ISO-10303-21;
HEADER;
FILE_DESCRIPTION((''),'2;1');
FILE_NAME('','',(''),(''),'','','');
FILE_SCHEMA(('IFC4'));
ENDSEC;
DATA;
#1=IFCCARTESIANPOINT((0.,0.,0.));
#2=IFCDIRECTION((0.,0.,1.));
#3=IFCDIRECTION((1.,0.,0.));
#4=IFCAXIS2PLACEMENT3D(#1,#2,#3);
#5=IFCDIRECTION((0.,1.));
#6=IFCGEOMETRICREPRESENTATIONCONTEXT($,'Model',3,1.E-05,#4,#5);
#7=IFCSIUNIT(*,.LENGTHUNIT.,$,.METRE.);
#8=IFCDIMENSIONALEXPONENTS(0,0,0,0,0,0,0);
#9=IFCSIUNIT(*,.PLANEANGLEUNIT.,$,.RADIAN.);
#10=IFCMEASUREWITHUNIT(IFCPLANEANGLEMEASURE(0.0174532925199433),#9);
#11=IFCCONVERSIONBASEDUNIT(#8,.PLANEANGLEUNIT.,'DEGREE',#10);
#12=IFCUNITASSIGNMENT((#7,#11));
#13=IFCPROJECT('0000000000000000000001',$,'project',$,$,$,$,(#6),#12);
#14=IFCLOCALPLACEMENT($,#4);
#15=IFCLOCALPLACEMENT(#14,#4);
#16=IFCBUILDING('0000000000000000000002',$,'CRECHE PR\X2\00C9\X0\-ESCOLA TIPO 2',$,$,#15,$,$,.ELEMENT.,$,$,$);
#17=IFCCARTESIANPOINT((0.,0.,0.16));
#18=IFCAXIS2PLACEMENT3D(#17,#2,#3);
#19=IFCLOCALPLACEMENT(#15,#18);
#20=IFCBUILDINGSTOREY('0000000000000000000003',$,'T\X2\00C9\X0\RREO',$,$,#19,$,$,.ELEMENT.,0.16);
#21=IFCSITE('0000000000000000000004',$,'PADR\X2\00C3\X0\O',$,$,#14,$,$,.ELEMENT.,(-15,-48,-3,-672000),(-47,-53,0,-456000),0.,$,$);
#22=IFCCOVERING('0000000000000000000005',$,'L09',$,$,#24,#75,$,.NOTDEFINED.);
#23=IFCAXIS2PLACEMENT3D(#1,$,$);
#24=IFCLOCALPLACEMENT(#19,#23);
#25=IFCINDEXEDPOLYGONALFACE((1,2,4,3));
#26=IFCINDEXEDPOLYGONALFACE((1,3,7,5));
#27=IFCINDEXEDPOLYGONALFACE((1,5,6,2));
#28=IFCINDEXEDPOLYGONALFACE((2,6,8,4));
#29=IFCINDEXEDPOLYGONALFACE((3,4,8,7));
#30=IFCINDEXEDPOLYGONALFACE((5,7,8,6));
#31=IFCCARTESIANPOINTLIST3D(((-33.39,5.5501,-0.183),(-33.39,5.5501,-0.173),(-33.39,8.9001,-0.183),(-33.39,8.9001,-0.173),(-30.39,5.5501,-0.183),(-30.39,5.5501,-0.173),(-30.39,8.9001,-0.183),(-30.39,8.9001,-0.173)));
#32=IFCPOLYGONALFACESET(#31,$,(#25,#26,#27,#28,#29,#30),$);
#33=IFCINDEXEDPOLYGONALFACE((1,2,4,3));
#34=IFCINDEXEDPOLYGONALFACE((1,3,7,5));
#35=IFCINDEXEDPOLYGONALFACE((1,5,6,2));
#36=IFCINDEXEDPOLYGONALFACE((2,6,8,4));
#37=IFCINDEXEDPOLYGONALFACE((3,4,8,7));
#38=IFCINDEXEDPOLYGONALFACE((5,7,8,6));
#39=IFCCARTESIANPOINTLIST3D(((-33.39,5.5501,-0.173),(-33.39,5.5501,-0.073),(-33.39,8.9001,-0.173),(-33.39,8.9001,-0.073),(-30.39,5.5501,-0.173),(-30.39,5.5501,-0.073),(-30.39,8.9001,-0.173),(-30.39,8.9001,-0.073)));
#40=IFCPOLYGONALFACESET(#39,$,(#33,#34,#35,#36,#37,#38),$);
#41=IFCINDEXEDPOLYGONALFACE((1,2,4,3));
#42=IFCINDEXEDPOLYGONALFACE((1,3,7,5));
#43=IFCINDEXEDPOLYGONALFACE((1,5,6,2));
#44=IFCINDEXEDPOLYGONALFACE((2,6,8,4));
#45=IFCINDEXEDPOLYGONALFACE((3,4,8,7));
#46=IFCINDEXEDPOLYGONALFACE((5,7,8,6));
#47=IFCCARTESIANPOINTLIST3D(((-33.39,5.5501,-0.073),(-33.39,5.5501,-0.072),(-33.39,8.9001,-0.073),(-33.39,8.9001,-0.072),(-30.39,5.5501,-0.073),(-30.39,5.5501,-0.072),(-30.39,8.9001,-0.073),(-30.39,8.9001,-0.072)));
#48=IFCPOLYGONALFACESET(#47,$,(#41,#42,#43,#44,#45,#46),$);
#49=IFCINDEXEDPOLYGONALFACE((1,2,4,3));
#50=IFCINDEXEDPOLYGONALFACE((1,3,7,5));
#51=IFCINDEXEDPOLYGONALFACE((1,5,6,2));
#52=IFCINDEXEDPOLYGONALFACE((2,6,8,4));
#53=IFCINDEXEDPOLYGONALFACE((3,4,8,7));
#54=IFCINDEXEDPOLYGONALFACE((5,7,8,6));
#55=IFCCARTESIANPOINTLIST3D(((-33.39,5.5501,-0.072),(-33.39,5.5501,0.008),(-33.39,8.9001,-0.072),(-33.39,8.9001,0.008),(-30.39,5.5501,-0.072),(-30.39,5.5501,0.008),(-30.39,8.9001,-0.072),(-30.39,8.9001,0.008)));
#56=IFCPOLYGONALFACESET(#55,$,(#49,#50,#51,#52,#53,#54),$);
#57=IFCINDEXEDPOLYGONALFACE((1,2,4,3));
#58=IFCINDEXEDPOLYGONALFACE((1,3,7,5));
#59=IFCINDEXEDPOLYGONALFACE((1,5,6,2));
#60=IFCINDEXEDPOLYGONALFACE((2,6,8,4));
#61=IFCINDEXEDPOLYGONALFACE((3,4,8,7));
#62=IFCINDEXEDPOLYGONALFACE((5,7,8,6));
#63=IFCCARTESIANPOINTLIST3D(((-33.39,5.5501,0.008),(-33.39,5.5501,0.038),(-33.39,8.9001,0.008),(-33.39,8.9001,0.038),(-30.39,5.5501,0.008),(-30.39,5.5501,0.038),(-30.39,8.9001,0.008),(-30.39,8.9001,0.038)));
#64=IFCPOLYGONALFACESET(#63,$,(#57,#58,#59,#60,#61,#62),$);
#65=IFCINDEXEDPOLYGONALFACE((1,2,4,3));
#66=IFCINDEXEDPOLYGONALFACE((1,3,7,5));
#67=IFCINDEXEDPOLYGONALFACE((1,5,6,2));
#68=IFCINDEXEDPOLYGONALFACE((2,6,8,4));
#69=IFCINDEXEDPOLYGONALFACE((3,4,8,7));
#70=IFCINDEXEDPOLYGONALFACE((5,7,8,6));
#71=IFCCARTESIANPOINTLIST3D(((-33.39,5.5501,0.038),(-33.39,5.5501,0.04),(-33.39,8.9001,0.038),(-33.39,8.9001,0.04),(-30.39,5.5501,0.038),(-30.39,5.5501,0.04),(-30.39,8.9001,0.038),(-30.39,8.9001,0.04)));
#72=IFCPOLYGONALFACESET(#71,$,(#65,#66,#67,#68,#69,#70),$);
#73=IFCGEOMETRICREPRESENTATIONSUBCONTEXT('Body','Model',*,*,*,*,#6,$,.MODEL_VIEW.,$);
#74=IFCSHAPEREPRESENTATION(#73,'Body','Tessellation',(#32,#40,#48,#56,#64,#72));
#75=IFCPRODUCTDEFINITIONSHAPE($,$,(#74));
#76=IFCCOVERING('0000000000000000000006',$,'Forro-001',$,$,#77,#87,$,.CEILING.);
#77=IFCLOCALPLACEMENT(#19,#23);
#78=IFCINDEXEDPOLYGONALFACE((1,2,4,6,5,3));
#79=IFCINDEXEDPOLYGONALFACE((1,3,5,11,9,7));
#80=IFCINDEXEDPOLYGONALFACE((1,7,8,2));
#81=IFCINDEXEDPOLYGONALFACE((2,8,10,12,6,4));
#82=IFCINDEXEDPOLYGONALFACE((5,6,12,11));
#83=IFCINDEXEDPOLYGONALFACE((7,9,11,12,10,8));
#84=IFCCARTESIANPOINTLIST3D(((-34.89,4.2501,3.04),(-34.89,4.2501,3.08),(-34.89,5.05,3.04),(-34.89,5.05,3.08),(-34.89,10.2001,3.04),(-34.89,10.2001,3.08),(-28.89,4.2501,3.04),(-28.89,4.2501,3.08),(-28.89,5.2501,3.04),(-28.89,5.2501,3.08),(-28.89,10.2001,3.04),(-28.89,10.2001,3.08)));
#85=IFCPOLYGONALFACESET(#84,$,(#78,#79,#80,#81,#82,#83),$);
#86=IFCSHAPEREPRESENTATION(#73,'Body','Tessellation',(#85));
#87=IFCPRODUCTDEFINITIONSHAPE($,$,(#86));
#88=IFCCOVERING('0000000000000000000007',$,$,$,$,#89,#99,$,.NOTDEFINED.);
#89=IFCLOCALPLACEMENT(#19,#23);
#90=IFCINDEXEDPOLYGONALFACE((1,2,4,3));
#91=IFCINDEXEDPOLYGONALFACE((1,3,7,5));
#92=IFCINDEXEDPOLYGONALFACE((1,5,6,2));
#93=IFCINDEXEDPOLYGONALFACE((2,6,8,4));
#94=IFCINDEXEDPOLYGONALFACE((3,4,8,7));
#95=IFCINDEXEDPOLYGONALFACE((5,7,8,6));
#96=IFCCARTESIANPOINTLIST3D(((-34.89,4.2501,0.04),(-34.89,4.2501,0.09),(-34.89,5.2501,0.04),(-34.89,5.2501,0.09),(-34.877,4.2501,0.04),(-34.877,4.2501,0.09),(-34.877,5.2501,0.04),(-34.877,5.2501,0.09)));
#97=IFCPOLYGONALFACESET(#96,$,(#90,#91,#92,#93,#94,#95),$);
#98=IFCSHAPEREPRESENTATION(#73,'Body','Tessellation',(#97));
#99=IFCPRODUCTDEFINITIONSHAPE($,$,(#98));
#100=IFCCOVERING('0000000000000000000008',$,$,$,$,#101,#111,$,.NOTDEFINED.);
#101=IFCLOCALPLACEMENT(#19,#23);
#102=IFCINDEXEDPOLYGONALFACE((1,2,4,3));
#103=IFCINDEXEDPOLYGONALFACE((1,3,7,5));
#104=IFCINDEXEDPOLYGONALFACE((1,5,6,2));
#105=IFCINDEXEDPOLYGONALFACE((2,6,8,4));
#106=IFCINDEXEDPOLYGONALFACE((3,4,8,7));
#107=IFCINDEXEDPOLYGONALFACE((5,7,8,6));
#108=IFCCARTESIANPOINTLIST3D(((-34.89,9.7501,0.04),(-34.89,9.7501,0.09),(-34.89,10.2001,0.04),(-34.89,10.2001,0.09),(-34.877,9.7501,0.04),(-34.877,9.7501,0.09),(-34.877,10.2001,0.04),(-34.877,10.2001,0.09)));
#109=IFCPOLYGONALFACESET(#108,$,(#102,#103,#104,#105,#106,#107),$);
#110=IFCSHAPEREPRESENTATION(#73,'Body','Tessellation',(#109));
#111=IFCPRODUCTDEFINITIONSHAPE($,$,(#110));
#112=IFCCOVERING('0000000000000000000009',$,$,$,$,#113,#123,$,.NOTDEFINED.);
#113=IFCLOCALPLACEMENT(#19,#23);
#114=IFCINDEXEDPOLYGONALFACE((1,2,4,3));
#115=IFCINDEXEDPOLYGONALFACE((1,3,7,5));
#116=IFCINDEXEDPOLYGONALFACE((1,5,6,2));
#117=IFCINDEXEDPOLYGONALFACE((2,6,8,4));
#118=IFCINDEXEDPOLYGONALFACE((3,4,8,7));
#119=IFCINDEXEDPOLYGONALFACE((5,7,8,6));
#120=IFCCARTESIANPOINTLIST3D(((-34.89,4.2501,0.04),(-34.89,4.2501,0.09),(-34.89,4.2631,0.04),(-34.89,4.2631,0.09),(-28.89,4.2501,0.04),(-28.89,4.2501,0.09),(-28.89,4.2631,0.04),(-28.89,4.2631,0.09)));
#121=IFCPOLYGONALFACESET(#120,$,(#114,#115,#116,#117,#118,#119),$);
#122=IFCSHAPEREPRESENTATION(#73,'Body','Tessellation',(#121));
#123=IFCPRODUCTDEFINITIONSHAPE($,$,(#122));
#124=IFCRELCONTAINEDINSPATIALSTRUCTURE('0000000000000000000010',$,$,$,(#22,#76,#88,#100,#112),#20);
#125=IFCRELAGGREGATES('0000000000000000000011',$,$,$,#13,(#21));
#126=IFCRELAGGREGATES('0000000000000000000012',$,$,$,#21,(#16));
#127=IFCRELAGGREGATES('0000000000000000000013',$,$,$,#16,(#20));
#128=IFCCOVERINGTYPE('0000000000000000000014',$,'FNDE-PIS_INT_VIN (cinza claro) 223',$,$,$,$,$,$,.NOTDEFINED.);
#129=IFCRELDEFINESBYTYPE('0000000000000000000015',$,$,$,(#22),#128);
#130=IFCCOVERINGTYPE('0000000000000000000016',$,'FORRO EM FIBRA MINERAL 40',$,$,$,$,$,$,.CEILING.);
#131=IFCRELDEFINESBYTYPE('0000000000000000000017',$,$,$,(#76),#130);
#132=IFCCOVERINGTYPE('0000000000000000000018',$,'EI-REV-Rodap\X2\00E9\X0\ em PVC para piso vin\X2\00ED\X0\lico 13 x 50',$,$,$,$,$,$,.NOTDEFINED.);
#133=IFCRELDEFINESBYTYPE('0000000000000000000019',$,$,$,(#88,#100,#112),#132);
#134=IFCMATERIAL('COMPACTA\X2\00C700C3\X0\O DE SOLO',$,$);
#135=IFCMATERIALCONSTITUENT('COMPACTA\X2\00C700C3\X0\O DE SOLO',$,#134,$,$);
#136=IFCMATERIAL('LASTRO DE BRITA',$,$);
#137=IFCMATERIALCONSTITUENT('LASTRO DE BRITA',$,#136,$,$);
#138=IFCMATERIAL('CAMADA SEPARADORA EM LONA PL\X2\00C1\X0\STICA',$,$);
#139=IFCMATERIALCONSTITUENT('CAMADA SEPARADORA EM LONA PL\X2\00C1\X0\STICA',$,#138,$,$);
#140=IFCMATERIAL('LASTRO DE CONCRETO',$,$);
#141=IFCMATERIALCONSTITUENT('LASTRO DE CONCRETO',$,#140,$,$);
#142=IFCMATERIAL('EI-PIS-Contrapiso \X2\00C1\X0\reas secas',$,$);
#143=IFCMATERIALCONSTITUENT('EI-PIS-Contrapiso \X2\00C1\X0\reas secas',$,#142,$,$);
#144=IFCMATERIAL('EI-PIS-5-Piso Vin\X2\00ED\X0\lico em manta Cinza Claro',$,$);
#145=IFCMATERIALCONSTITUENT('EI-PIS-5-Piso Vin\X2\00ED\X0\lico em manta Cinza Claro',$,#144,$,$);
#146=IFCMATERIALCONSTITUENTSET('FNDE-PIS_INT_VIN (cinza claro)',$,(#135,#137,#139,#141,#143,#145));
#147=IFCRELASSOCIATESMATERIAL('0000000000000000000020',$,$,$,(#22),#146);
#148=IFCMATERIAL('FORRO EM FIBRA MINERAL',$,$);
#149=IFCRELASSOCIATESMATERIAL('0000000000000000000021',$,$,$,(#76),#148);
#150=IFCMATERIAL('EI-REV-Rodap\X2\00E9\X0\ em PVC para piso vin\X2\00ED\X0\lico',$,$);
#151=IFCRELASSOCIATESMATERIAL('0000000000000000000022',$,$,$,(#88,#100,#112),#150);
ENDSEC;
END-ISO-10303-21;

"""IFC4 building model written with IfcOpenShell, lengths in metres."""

from ifc_helpers import new_model, entity, si_unit, converted_unit, direction, frame, frame_2d, origin_with_axes, place, context, subcontext, project, spatial, line, indexed_curve, rectangle, outline, extrude, material, constituent, constituent_set, type_object, element, save


model = new_model("IFC4")

# Units and contexts
model_context = context("Model", 3, precision=1e-05, world=origin_with_axes(), true_north=direction((0.0, 1.0)))
body_context = subcontext(model_context, "Body", "Model", "MODEL_VIEW")
ifc_project = project(units=[si_unit("LENGTHUNIT", "METRE"), converted_unit("PLANEANGLEUNIT", "DEGREE", entity("IfcPlaneAngleMeasure", 0.0174532925199433), si_unit("PLANEANGLEUNIT", "RADIAN"), dimensions=[0, 0, 0, 0, 0, 0, 0])], contexts=[model_context])

# Site, building, storey
site_placement = place(None, origin_with_axes())
site = spatial("IfcSite", under=ifc_project, at=site_placement, Name="PADRÃO", CompositionType="ELEMENT", RefLatitude=(-15, -48, -3, -672000), RefLongitude=(-47, -53, 0, -456000), RefElevation=0.0)
building_placement = place(site_placement, origin_with_axes())
building = spatial("IfcBuilding", under=site, at=building_placement, Name="CRECHE PRÉ-ESCOLA TIPO 2", CompositionType="ELEMENT")
storey_placement = place(building_placement, frame((0.0, 0.0, 0.16), z_axis=(0.0, 0.0, 1.0), x_axis=(1.0, 0.0, 0.0)))
storey = spatial("IfcBuildingStorey", under=building, at=storey_placement, Name="TÉRREO", CompositionType="ELEMENT", Elevation=0.16)

# Coverings
ifc_material_1 = material(Name="COMPACTAÇÃO DE SOLO")
ifc_material_2 = material(Name="LASTRO DE BRITA")
ifc_material_3 = material(Name="CAMADA SEPARADORA EM LONA PLÁSTICA")
ifc_material_4 = material(Name="LASTRO DE CONCRETO")
ifc_material_5 = material(Name="EI-PIS-Contrapiso Áreas secas")
ifc_material_6 = material(Name="EI-PIS-5-Piso Vinílico em manta Cinza Claro")
covering_type_1 = type_object("IfcCoveringType", Name="FNDE-PIS_INT_VIN (cinza claro) 223", PredefinedType="NOTDEFINED")
ifc_constituent_1 = constituent(ifc_material_1, Name="COMPACTAÇÃO DE SOLO")
ifc_constituent_2 = constituent(ifc_material_2, Name="LASTRO DE BRITA")
ifc_constituent_3 = constituent(ifc_material_3, Name="CAMADA SEPARADORA EM LONA PLÁSTICA")
ifc_constituent_4 = constituent(ifc_material_4, Name="LASTRO DE CONCRETO")
ifc_constituent_5 = constituent(ifc_material_5, Name="EI-PIS-Contrapiso Áreas secas")
ifc_constituent_6 = constituent(ifc_material_6, Name="EI-PIS-5-Piso Vinílico em manta Cinza Claro")
ifc_constituent_set_1 = constituent_set(constituents=[ifc_constituent_1, ifc_constituent_2, ifc_constituent_3, ifc_constituent_4, ifc_constituent_5, ifc_constituent_6], Name="FNDE-PIS_INT_VIN (cinza claro)")
covering_1_placement = place(storey_placement, frame((-33.39, 8.9001, 0.04), z_axis=(0.0, 0.0, 1.0), x_axis=(1.0, 0.0, 0.0)))
element("IfcCovering", 1, at=covering_1_placement, inside=storey, type_object=covering_type_1, material=ifc_constituent_set_1, Name="L09", PredefinedType="NOTDEFINED", context=body_context, shape_type="SweptSolid", body=[
    extrude(outline(indexed_curve([(0.0, 0.0), (0.0, -3.35), (3.0, -3.35), (3.0, 0.0)], segments=[line(1, 2, 3, 4, 1)])), frame((0.0, 0.0, -0.223), z_axis=(0.0, 0.0, 1.0), x_axis=(1.0, 0.0, 0.0)), (0.0, 0.0, 1.0), 0.01),
    extrude(outline(indexed_curve([(0.0, 0.0), (0.0, -3.35), (3.0, -3.35), (3.0, 0.0)], segments=[line(1, 2, 3, 4, 1)])), frame((0.0, 0.0, -0.213), z_axis=(0.0, 0.0, 1.0), x_axis=(1.0, 0.0, 0.0)), (0.0, 0.0, 1.0), 0.1),
    extrude(outline(indexed_curve([(0.0, 0.0), (0.0, -3.35), (3.0, -3.35), (3.0, 0.0)], segments=[line(1, 2, 3, 4, 1)])), frame((0.0, 0.0, -0.113), z_axis=(0.0, 0.0, 1.0), x_axis=(1.0, 0.0, 0.0)), (0.0, 0.0, 1.0), 0.001),
    extrude(outline(indexed_curve([(0.0, 0.0), (0.0, -3.35), (3.0, -3.35), (3.0, 0.0)], segments=[line(1, 2, 3, 4, 1)])), frame((0.0, 0.0, -0.112), z_axis=(0.0, 0.0, 1.0), x_axis=(1.0, 0.0, 0.0)), (0.0, 0.0, 1.0), 0.08),
    extrude(outline(indexed_curve([(0.0, 0.0), (0.0, -3.35), (3.0, -3.35), (3.0, 0.0)], segments=[line(1, 2, 3, 4, 1)])), frame((0.0, 0.0, -0.032), z_axis=(0.0, 0.0, 1.0), x_axis=(1.0, 0.0, 0.0)), (0.0, 0.0, 1.0), 0.03),
    extrude(outline(indexed_curve([(0.0, 0.0), (0.0, -3.35), (3.0, -3.35), (3.0, 0.0)], segments=[line(1, 2, 3, 4, 1)])), frame((0.0, 0.0, -0.002), z_axis=(0.0, 0.0, 1.0), x_axis=(1.0, 0.0, 0.0)), (0.0, 0.0, 1.0), 0.002),
])
ifc_material_7 = material(Name="FORRO EM FIBRA MINERAL")
covering_type_2 = type_object("IfcCoveringType", Name="FORRO EM FIBRA MINERAL 40", PredefinedType="CEILING")
covering_2_placement = place(storey_placement, frame((-34.89, 5.05, 3.04), z_axis=(0.0, 0.0, 1.0), x_axis=(1.0, 0.0, 0.0)))
element("IfcCovering", 2, at=covering_2_placement, inside=storey, type_object=covering_type_2, material=ifc_material_7, Name="Forro-001", PredefinedType="CEILING", context=body_context, shape_type="SweptSolid", body=[
    extrude(outline(indexed_curve([(0.0, 0.0), (0.0, 0.0), (0.0, -0.7999), (5.9999, -0.7999), (5.9999, 0.2001), (6.0, 0.2001), (6.0, 5.1501), (0.0, 5.1501)], segments=[line(1, 2, 3, 4, 5, 6, 7, 8, 1)])), origin_with_axes(), (0.0, 0.0, 1.0), 0.04),
])
ifc_material_8 = material(Name="EI-REV-Rodapé em PVC para piso vinílico")
covering_type_3 = type_object("IfcCoveringType", Name="EI-REV-Rodapé em PVC para piso vinílico 13 x 50", PredefinedType="NOTDEFINED")
covering_3_placement = place(storey_placement, frame((-34.89, 5.2501, 0.04), z_axis=(0.0, 0.0, 1.0), x_axis=(-1.0, 0.0, 0.0)))
element("IfcCovering", 3, at=covering_3_placement, inside=storey, type_object=covering_type_3, material=ifc_material_8, PredefinedType="NOTDEFINED", context=body_context, shape_type="SweptSolid", body=[
    extrude(rectangle(XDim=0.05, YDim=0.013, at=frame_2d((0.025, -0.0065), x_axis=(1.0, 0.0))), frame((0.0, 0.0, 0.0), z_axis=(0.0, 1.0, 0.0), x_axis=(0.0, 0.0, 1.0)), (0.0, 0.0, 1.0), 0.9999),
])
covering_4_placement = place(storey_placement, frame((-34.89, 10.2001, 0.04), z_axis=(0.0, 0.0, 1.0), x_axis=(-1.0, 0.0, 0.0)))
element("IfcCovering", 4, at=covering_4_placement, inside=storey, type_object=covering_type_3, material=ifc_material_8, PredefinedType="NOTDEFINED", context=body_context, shape_type="SweptSolid", body=[
    extrude(rectangle(XDim=0.05, YDim=0.013, at=frame_2d((0.025, -0.0065), x_axis=(1.0, 0.0))), frame((0.0, 0.0, 0.0), z_axis=(0.0, 1.0, 0.0), x_axis=(0.0, 0.0, 1.0)), (0.0, 0.0, 1.0), 0.45),
])
covering_5_placement = place(storey_placement, frame((-34.89, 4.2501, 0.04), z_axis=(0.0, 0.0, 1.0), x_axis=(0.0, -1.0, 0.0)))
element("IfcCovering", 5, at=covering_5_placement, inside=storey, type_object=covering_type_3, material=ifc_material_8, PredefinedType="NOTDEFINED", context=body_context, shape_type="SweptSolid", body=[
    extrude(rectangle(XDim=0.05, YDim=0.013, at=frame_2d((0.025, -0.0065), x_axis=(1.0, 0.0))), frame((0.0, 0.0, 0.0), z_axis=(0.0, 1.0, 0.0), x_axis=(0.0, 0.0, 1.0)), (0.0, 0.0, 1.0), 5.9999),
])

save(model, "model.ifc")
